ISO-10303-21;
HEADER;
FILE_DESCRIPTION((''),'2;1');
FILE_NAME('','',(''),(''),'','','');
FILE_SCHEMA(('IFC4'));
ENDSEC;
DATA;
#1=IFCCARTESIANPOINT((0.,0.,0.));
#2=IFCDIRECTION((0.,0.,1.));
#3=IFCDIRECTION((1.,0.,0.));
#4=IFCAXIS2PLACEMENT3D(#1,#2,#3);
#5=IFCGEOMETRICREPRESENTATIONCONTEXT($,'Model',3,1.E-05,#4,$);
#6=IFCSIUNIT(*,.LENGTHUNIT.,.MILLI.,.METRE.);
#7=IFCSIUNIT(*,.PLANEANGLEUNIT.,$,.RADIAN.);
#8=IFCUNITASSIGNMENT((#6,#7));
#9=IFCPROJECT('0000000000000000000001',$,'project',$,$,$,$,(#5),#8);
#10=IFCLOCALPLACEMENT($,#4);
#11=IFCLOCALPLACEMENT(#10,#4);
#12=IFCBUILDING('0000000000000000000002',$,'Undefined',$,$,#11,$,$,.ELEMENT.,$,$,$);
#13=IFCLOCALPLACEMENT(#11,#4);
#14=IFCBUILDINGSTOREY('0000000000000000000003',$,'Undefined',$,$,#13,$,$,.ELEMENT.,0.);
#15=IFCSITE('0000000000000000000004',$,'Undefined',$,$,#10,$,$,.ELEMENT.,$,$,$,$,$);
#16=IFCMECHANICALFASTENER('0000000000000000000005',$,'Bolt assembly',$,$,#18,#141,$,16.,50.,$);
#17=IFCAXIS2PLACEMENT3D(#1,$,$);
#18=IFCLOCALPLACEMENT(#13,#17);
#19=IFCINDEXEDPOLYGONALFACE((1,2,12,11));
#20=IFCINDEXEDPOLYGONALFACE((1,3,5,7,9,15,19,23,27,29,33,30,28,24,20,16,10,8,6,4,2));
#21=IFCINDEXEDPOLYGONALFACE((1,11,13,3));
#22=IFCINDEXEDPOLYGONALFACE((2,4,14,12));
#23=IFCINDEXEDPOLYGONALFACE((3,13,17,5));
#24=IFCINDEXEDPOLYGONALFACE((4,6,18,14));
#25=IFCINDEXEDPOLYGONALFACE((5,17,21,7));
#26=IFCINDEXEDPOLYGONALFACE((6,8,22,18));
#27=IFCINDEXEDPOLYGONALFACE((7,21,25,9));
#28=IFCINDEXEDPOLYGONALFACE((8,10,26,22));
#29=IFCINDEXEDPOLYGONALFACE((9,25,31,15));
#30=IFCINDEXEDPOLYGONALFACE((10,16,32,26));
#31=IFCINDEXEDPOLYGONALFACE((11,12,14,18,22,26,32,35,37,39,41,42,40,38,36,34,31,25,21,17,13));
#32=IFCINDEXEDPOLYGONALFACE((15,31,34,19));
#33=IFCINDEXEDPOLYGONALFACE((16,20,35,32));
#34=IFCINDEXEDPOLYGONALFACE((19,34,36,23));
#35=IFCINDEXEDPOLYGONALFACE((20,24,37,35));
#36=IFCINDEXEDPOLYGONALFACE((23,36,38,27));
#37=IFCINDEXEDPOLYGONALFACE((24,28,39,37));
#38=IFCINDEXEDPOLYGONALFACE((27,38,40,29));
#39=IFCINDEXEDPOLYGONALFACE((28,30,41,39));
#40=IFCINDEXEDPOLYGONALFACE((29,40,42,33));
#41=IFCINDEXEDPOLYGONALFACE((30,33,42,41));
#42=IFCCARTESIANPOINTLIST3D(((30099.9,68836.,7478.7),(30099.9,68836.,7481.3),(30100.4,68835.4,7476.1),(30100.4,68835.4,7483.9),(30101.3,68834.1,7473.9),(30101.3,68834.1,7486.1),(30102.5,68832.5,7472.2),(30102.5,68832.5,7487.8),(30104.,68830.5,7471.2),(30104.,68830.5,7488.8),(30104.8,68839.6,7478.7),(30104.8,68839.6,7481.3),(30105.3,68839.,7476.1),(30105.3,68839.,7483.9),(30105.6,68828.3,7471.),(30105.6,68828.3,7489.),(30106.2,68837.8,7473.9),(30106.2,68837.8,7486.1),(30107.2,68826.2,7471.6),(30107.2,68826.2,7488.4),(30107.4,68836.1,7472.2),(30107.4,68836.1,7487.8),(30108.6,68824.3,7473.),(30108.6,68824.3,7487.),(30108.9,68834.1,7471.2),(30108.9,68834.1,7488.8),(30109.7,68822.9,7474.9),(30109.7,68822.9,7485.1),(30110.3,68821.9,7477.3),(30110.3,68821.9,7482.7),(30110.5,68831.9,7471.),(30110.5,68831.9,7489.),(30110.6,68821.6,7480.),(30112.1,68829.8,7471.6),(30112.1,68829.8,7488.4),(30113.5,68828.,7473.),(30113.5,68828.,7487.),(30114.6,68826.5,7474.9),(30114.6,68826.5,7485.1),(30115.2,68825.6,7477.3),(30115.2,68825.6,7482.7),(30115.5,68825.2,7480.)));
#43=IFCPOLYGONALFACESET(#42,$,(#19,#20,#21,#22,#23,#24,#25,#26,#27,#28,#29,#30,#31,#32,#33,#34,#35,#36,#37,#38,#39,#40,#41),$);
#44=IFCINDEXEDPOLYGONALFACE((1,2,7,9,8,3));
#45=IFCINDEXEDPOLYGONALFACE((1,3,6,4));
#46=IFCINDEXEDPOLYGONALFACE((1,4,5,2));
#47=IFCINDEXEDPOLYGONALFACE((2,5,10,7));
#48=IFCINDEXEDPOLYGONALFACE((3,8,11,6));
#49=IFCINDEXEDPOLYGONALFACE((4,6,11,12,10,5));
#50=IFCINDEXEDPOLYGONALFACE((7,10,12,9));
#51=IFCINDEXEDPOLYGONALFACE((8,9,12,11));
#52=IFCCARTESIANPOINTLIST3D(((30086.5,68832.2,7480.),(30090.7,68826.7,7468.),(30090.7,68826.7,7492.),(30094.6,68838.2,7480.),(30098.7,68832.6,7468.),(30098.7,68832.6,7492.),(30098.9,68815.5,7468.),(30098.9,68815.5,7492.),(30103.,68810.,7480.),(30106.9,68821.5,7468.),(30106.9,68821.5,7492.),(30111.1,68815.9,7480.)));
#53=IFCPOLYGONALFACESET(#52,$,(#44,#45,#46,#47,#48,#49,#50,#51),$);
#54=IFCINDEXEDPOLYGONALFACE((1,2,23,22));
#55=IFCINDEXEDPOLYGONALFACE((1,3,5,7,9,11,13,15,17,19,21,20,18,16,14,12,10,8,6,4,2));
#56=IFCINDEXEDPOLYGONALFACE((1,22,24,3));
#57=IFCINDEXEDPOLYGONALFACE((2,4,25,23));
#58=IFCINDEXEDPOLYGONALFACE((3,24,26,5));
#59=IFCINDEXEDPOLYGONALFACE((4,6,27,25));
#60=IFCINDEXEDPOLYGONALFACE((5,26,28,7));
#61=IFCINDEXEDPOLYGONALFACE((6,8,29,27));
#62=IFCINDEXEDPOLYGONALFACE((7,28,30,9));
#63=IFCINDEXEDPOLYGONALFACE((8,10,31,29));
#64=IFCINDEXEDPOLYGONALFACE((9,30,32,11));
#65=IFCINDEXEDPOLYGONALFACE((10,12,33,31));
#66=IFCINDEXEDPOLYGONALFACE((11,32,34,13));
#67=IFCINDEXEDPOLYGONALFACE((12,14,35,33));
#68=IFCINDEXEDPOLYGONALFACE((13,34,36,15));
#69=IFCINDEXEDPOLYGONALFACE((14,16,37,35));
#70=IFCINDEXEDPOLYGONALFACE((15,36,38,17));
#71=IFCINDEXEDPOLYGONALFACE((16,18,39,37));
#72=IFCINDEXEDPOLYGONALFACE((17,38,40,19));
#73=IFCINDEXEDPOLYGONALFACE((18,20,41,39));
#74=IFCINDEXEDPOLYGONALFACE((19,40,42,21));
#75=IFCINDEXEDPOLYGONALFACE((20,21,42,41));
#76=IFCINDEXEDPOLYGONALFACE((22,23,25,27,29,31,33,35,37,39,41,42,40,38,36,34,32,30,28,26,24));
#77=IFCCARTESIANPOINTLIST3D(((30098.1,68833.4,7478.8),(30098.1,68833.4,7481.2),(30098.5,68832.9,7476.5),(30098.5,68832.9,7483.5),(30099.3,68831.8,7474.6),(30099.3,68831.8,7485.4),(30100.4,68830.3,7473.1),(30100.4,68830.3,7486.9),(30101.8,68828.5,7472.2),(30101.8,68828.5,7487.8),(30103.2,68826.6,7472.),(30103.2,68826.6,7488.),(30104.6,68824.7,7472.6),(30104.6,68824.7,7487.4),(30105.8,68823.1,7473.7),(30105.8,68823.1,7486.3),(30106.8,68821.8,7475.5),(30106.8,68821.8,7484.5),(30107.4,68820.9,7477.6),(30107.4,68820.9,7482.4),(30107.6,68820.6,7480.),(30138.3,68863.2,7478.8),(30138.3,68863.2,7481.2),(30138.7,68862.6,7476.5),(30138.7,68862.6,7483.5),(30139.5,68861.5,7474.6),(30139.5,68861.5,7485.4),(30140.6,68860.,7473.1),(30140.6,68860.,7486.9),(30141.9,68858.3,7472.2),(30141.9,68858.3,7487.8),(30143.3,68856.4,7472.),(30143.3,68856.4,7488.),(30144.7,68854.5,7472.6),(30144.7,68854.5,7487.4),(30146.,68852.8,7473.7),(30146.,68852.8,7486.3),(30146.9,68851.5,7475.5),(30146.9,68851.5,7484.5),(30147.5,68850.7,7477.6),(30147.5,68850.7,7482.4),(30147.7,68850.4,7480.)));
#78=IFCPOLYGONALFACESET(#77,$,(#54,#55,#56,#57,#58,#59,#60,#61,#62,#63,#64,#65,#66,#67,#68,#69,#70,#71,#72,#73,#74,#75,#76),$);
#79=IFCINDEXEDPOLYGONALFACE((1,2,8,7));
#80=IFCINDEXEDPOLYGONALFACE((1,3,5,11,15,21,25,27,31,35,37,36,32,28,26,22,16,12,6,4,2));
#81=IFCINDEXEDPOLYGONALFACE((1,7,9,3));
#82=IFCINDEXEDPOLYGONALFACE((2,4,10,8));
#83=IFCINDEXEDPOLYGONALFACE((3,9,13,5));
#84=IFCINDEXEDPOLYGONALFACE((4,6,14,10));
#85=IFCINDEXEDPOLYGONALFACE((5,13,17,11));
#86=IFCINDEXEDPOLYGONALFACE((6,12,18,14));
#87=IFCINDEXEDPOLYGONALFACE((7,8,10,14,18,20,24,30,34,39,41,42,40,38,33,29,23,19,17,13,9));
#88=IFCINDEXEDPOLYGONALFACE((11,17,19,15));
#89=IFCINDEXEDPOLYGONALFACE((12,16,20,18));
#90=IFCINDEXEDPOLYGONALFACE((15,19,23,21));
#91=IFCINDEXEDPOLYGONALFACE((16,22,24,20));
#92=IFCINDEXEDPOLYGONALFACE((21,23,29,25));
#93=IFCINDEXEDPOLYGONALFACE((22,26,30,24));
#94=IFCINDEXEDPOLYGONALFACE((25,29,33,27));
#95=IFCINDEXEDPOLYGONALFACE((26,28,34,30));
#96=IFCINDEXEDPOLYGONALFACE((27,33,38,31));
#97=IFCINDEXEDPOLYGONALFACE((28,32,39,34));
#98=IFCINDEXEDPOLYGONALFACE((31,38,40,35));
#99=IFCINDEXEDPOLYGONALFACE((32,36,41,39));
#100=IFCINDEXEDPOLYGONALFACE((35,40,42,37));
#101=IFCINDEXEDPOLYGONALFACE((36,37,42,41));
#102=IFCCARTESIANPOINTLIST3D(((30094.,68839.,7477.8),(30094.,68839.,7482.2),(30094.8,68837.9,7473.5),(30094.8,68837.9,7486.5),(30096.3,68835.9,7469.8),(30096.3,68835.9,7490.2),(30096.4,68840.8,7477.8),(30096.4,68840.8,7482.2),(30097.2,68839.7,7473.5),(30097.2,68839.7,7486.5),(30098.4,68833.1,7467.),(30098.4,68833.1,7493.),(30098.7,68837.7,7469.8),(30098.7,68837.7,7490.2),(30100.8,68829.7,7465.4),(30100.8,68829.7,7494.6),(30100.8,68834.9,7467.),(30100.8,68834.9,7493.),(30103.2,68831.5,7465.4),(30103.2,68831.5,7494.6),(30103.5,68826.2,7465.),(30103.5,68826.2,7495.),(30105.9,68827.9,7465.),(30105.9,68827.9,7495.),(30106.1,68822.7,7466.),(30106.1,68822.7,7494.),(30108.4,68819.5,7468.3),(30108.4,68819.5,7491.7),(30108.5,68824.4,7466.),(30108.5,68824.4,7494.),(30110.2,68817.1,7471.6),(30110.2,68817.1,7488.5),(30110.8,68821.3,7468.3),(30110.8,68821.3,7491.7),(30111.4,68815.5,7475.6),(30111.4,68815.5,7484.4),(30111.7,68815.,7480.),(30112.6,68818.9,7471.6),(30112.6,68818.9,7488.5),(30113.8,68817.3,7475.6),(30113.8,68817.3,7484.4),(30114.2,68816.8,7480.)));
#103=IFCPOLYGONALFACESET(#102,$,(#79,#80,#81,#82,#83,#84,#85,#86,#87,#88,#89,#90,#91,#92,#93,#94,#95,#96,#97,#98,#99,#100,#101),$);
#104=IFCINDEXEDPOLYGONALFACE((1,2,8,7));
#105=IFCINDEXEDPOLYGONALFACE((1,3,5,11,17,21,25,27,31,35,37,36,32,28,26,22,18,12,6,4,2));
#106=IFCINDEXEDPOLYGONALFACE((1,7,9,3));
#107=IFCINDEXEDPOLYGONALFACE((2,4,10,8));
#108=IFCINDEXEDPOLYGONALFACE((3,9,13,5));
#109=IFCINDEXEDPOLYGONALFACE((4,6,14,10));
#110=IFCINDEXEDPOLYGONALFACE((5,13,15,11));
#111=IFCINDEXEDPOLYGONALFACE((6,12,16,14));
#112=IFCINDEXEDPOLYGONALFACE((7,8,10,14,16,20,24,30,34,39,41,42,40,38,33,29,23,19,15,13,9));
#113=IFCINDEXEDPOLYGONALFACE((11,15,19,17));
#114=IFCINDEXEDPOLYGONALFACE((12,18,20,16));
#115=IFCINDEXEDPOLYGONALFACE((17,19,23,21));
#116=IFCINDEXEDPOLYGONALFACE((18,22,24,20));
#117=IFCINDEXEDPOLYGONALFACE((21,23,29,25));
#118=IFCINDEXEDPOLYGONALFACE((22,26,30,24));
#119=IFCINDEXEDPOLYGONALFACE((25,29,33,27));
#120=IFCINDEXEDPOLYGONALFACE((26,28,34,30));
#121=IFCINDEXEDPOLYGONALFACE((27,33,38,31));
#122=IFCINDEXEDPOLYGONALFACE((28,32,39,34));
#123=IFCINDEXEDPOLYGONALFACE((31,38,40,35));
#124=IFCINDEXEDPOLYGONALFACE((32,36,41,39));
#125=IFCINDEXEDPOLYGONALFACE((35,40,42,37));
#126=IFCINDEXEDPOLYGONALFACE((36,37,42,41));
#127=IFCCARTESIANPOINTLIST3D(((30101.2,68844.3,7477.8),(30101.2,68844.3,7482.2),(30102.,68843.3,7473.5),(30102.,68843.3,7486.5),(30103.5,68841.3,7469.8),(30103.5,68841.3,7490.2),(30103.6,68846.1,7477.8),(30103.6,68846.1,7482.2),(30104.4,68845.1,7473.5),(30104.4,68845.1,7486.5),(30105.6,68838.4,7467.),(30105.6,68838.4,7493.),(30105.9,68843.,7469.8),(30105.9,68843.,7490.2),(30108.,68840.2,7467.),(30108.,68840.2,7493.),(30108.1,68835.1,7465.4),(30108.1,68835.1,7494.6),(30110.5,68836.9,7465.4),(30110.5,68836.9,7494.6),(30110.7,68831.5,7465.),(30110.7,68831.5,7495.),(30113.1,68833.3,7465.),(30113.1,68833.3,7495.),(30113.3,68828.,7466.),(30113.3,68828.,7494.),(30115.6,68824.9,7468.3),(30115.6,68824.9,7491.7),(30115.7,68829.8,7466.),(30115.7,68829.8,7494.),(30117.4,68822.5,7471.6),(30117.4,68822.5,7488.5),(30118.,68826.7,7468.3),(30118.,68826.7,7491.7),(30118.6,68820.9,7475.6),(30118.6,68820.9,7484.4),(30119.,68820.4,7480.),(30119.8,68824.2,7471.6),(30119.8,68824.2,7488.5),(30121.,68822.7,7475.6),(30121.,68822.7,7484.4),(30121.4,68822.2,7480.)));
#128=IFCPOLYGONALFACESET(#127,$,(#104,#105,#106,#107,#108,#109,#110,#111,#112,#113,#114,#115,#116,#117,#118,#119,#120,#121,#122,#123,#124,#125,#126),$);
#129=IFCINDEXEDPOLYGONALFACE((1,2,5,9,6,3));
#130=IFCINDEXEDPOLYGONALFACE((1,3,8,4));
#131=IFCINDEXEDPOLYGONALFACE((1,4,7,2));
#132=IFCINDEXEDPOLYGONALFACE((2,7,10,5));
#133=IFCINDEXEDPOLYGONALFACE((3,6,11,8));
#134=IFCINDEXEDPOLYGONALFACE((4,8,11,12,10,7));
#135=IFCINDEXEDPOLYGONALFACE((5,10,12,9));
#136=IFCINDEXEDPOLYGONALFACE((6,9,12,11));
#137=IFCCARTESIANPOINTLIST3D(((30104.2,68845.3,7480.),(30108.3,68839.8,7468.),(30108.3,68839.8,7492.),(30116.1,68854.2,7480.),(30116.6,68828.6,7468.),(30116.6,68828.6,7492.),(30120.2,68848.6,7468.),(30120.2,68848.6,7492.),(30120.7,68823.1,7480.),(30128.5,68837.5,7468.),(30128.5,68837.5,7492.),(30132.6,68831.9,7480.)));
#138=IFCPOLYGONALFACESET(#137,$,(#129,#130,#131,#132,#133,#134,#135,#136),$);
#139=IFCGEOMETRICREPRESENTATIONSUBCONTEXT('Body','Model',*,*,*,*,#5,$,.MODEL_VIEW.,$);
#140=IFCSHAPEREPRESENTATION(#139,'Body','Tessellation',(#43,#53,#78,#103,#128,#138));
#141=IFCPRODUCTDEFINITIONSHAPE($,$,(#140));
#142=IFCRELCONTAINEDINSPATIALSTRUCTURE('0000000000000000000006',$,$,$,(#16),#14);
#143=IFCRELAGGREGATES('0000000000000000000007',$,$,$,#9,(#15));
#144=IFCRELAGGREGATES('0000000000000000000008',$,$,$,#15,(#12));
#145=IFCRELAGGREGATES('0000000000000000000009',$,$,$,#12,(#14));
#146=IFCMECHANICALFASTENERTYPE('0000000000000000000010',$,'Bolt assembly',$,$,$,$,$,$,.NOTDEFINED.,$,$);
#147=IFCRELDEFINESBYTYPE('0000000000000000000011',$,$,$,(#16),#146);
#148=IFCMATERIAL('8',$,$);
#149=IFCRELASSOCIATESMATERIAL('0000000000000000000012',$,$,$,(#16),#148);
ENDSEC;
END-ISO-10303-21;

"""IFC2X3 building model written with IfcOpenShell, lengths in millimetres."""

from ifc_helpers import new_model, si_unit, frame, origin_with_axes, origin_2d_with_axis, place, context, subcontext, project, spatial, polyline, circle, outline, extrude, source, transform, mapped, material, type_object, element, save


model = new_model("IFC2X3")

# Units and contexts
model_context = context("Model", 3, precision=1e-05, world=origin_with_axes())
body_context = subcontext(model_context, "Body", "Model", "MODEL_VIEW")
ifc_project = project(units=[si_unit("LENGTHUNIT", "METRE", prefix="MILLI"), si_unit("PLANEANGLEUNIT", "RADIAN")], contexts=[model_context])

# Site, building, storey
site_placement = place(None, origin_with_axes())
site = spatial("IfcSite", under=ifc_project, at=site_placement, Name="Undefined", CompositionType="ELEMENT")
building_placement = place(site_placement, origin_with_axes())
building = spatial("IfcBuilding", under=site, at=building_placement, Name="Undefined", CompositionType="ELEMENT")
storey_placement = place(building_placement, origin_with_axes())
storey = spatial("IfcBuildingStorey", under=building, at=storey_placement, Name="Undefined", CompositionType="ELEMENT", Elevation=0.0)

# Shared definitions
ifc_material_1 = material(Name="8")
mechanical_fastener_type = type_object("IfcMechanicalFastenerType", Name="Bolt assembly")

# Mechanical fastener
shared_shape_1 = source(origin_with_axes(), body_context, "Body", "SweptSolid", [
    extrude(circle(Radius=9.0, at=origin_2d_with_axis()), frame((0.0, 11.5, 0.0), z_axis=(0.0, 1.0, 0.0), x_axis=(1.0, 0.0, 0.0)), (0.0, 0.0, 1.0), 6.1),
    extrude(outline(polyline([(13.9, 0.0), (6.9, 12.0), (-6.9, 12.0), (-13.9, 0.0), (-6.9, -12.0), (6.9, -12.0), (13.9, 0.0)])), frame((0.0, -1.5, 0.0), z_axis=(0.0, 1.0, 0.0), x_axis=(1.0, 0.0, 0.0)), (0.0, 0.0, 1.0), 10.0),
    extrude(circle(Radius=8.0, at=origin_2d_with_axis()), frame((0.0, 8.5, 0.0), z_axis=(0.0, 1.0, 0.0), x_axis=(1.0, 0.0, 0.0)), (0.0, 0.0, 1.0), 50.0),
    extrude(circle(Radius=15.0, at=origin_2d_with_axis()), frame((0.0, 8.5, 0.0), z_axis=(0.0, 1.0, 0.0), x_axis=(1.0, 0.0, 0.0)), (0.0, 0.0, 1.0), 3.0),
    extrude(circle(Radius=15.0, at=origin_2d_with_axis()), frame((0.0, 17.5, 0.0), z_axis=(0.0, 1.0, 0.0), x_axis=(1.0, 0.0, 0.0)), (0.0, 0.0, 1.0), 3.0),
    extrude(outline(polyline([(13.9, 0.0), (6.9, 12.0), (-6.9, 12.0), (-13.9, 0.0), (-6.9, -12.0), (6.9, -12.0), (13.9, 0.0)])), frame((0.0, 20.5, 0.0), z_axis=(0.0, 1.0, 0.0), x_axis=(1.0, 0.0, 0.0)), (0.0, 0.0, 1.0), 14.8),
])
for number, where, z_axis, x_axis, name in (
    (1, (30096.0, 68822.0, 7480.0), (0.0, 0.0, 1.0), (0.595463, -0.803383, 0.0), "Bolt assembly"),
):
    element("IfcMechanicalFastener", number, at=place(storey_placement, frame(where, z_axis=z_axis, x_axis=x_axis)), inside=storey, type_object=mechanical_fastener_type, material=ifc_material_1, Name=name, NominalDiameter=16.0, NominalLength=50.0, context=body_context, shape_type="MappedRepresentation", body=[
        mapped(shared_shape_1, transform((0.0, 0.0, 0.0))),
    ])

save(model, "model.ifc")
